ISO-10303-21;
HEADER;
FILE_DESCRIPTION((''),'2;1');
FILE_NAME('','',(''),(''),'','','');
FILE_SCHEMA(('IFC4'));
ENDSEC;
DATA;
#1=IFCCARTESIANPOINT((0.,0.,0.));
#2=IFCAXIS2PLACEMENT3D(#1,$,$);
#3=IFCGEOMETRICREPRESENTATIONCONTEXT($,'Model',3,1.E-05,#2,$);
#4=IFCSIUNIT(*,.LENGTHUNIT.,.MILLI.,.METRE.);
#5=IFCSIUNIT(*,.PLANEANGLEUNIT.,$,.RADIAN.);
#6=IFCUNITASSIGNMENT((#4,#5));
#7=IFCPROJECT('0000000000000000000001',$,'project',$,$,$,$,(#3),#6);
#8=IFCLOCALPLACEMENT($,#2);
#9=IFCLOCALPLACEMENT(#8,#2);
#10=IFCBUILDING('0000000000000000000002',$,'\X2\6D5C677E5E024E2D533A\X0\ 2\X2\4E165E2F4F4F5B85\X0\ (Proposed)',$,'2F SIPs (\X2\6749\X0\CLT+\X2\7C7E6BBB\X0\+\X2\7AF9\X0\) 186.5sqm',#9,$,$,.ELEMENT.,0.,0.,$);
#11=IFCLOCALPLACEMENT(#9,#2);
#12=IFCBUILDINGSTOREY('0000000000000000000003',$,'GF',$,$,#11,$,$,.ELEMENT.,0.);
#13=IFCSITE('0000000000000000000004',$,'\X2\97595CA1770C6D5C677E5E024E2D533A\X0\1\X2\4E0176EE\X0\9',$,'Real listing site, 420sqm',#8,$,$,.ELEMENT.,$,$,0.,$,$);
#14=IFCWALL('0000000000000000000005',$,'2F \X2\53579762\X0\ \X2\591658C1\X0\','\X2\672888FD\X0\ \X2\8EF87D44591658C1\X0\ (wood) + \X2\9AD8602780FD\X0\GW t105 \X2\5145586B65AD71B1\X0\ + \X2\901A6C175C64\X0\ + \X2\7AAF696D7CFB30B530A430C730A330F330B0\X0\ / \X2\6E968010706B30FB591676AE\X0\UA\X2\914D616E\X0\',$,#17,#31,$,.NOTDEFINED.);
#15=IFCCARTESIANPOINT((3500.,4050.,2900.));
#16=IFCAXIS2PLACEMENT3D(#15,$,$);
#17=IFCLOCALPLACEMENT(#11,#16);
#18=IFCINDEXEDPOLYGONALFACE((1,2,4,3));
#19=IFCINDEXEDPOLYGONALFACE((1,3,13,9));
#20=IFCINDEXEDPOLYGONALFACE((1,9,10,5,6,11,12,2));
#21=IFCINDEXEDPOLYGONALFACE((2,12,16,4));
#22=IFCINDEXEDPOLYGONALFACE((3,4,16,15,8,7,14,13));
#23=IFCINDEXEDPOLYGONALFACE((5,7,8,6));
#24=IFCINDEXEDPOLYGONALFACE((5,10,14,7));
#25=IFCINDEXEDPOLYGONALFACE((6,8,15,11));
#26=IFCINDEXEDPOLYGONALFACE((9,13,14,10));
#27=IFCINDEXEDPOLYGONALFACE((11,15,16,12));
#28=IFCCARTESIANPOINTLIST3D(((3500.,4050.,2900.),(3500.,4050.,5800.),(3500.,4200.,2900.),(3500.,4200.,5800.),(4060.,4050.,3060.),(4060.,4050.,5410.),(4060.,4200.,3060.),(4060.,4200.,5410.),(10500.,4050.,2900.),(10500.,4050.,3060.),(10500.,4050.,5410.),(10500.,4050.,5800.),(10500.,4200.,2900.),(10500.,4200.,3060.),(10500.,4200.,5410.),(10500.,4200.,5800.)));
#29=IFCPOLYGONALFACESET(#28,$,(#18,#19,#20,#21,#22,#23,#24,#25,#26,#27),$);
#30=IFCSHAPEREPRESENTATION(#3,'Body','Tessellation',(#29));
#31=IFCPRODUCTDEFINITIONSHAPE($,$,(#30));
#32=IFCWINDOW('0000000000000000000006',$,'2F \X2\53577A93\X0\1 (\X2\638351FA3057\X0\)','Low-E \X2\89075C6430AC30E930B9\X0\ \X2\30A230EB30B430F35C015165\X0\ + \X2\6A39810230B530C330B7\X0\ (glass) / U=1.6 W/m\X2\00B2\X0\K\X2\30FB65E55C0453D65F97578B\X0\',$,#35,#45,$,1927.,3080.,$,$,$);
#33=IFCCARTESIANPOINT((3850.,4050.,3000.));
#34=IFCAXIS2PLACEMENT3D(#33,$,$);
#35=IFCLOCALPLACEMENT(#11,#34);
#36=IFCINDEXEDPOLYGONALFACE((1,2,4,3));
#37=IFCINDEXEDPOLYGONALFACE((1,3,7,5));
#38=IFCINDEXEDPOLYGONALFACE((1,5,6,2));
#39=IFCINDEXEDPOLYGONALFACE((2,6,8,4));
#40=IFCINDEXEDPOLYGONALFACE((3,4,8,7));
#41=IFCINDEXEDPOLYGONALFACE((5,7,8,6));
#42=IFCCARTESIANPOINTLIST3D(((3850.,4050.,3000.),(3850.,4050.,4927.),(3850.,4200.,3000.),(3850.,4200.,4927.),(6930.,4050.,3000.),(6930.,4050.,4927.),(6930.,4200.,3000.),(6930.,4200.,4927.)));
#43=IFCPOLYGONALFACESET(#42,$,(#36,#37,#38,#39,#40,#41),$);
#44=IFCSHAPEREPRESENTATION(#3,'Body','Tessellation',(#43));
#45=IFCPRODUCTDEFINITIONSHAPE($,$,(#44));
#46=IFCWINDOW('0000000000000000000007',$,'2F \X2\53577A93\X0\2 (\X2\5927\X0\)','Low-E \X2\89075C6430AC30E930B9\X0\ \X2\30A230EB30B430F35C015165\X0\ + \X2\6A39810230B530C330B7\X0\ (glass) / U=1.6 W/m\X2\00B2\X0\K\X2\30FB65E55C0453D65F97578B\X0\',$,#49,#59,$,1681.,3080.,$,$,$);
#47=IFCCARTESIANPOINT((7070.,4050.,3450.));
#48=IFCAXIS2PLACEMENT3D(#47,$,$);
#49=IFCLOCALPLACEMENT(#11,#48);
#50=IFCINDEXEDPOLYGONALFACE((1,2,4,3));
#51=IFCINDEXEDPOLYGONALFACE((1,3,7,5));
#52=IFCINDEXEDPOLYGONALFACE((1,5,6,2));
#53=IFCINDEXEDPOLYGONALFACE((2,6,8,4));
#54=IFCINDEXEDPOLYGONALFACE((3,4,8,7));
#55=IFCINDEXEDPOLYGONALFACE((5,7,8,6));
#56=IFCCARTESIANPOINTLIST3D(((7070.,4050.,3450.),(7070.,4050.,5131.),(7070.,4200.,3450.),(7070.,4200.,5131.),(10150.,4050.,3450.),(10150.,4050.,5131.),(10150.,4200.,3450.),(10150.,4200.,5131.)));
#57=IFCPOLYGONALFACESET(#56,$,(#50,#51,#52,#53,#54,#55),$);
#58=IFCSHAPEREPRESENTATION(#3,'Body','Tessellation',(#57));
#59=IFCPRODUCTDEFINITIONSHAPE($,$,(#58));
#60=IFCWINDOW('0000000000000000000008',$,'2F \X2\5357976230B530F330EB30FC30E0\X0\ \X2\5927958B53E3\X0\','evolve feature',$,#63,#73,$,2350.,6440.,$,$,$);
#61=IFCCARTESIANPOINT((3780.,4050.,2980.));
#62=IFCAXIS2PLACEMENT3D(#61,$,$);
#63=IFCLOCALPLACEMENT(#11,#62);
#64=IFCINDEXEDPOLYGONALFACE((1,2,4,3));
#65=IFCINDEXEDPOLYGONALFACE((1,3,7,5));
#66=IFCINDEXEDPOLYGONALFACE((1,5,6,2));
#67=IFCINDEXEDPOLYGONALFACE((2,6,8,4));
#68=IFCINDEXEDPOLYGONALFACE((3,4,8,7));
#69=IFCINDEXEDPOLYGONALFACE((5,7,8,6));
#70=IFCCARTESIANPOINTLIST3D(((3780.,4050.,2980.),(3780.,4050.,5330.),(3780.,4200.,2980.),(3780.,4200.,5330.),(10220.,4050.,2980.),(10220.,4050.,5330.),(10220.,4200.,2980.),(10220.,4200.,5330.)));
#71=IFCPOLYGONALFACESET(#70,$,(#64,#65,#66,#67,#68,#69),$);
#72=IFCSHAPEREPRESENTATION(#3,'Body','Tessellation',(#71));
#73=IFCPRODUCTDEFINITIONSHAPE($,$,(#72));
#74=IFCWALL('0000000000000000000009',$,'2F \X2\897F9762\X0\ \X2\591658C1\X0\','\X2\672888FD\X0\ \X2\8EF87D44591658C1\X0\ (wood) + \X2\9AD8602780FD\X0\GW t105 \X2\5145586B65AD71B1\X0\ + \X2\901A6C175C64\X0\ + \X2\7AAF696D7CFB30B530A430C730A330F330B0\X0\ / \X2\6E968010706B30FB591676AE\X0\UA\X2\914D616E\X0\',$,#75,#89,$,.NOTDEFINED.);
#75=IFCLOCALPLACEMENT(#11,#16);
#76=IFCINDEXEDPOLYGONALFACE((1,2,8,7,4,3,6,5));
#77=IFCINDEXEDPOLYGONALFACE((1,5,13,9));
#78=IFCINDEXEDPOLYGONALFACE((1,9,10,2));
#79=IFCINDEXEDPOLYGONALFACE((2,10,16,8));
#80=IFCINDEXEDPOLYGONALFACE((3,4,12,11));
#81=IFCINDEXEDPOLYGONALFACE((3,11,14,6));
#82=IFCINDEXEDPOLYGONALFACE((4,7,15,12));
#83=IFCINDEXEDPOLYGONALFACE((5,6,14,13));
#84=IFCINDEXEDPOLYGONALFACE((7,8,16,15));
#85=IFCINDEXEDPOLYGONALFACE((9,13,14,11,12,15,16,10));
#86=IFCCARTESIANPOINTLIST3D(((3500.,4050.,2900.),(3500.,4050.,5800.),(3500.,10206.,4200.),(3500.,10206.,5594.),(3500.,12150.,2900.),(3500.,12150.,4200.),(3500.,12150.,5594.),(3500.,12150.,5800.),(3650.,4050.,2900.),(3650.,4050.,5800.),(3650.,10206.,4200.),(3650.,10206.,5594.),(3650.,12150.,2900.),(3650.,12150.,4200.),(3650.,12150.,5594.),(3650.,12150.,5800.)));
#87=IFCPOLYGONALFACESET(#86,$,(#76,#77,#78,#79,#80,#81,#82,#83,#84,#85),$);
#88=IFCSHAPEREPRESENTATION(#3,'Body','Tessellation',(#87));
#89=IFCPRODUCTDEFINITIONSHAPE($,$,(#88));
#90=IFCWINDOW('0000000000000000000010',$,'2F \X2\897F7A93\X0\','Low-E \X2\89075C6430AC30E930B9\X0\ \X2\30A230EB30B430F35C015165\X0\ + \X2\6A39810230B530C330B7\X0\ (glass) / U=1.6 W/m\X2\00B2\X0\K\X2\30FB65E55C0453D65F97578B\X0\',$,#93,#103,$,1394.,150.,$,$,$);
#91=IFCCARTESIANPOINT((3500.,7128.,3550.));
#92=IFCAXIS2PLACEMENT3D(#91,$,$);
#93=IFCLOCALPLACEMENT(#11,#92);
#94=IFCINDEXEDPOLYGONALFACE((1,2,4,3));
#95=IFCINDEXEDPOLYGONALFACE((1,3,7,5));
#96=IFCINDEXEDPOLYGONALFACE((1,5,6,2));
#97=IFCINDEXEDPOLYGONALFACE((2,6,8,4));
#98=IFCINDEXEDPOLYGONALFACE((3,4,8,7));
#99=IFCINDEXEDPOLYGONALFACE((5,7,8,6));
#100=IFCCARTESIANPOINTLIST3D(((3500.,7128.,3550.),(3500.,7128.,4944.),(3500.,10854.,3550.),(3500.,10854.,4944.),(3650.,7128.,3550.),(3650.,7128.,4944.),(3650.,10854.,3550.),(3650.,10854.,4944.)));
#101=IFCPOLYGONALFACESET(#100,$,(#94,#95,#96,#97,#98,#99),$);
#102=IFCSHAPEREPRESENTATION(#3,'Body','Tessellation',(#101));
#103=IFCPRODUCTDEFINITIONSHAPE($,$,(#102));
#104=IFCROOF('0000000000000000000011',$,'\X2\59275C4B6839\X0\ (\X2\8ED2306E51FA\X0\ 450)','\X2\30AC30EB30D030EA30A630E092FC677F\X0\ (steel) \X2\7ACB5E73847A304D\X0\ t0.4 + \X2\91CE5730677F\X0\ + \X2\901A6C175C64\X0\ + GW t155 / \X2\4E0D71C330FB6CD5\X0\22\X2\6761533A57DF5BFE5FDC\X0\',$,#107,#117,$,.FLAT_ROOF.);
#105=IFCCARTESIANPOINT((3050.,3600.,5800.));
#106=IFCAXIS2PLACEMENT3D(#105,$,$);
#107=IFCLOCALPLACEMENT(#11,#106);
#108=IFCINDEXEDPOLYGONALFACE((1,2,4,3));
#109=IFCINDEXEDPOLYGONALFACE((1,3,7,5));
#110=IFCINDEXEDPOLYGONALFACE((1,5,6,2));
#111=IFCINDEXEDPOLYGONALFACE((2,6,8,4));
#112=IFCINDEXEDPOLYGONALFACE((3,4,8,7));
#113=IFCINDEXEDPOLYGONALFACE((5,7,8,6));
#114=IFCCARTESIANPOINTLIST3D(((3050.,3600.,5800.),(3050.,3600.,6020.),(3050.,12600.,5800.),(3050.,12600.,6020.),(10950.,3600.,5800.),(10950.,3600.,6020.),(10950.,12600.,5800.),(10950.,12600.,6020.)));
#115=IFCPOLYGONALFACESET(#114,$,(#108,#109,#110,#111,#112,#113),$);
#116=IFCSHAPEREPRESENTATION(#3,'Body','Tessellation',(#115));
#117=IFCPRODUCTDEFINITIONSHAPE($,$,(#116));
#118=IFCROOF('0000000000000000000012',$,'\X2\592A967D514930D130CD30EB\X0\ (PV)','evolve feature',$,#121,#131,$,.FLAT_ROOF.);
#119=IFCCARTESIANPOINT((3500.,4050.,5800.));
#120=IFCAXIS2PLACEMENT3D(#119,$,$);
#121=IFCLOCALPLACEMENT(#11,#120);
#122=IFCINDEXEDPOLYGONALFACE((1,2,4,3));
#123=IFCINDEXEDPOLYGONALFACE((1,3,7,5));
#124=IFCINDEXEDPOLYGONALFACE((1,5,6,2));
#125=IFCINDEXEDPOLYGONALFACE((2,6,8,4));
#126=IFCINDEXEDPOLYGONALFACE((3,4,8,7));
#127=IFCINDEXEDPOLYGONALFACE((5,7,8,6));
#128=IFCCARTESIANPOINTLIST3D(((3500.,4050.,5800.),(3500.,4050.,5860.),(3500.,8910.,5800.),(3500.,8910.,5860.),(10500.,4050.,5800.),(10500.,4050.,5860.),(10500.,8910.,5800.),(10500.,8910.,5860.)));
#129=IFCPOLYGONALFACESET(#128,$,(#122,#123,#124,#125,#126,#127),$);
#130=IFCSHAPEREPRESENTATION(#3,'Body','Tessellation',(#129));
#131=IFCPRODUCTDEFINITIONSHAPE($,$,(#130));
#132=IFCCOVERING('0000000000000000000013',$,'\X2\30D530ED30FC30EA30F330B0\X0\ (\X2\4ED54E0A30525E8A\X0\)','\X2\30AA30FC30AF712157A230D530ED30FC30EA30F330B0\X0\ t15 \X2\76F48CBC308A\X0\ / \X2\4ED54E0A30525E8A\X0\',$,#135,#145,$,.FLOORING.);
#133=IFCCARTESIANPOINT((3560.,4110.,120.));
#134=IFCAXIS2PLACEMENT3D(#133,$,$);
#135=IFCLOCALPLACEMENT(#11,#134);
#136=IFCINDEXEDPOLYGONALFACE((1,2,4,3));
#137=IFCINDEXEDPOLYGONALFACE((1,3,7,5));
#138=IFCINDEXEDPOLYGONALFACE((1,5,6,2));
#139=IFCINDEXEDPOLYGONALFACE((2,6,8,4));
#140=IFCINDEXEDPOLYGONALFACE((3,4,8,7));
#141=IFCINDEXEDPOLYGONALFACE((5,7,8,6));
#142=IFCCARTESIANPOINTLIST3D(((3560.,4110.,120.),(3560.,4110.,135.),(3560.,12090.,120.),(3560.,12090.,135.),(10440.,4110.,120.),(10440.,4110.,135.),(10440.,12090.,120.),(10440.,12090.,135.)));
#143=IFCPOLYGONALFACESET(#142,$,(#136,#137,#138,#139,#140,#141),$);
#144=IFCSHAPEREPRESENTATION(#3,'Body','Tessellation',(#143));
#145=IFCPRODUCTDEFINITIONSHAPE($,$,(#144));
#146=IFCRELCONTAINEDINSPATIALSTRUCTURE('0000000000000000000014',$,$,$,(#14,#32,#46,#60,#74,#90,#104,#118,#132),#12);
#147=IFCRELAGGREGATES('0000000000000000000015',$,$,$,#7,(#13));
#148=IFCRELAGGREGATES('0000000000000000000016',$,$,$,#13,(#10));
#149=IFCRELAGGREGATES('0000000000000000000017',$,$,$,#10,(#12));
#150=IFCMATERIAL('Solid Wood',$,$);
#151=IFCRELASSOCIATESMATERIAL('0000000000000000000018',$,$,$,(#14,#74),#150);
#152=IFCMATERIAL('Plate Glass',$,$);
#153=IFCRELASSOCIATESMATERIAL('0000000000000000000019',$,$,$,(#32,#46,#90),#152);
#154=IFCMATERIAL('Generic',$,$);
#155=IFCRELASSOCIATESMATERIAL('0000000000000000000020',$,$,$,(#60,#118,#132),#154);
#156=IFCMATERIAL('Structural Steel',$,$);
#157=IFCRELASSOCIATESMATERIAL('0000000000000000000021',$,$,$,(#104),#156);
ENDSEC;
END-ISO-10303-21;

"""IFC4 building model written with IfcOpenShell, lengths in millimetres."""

from ifc_helpers import new_model, si_unit, frame, frame_2d, origin, place, context, project, spatial, rectangle, extrude, material, element, fill, save


model = new_model("IFC4")

# Units and contexts
model_context = context("Model", 3, precision=1e-05, world=origin())
ifc_project = project(units=[si_unit("LENGTHUNIT", "METRE", prefix="MILLI"), si_unit("PLANEANGLEUNIT", "RADIAN")], contexts=[model_context])

# Site, building, storey
site_placement = place(None, origin())
site = spatial("IfcSite", under=ifc_project, at=site_placement, Name="静岡県浜松市中区1丁目9", ObjectType="Real listing site, 420sqm", CompositionType="ELEMENT", RefElevation=0.0)
building_placement = place(site_placement, origin())
building = spatial("IfcBuilding", under=site, at=building_placement, Name="浜松市中区 2世帯住宅 (Proposed)", ObjectType="2F SIPs (杉CLT+籾殻+竹) 186.5sqm", CompositionType="ELEMENT", ElevationOfRefHeight=0.0, ElevationOfTerrain=0.0)
storey_placement = place(building_placement, origin())
storey = spatial("IfcBuildingStorey", under=building, at=storey_placement, Name="GF", CompositionType="ELEMENT", Elevation=0.0)

# Shared definitions
ifc_material_1 = material(Name="Solid Wood")
ifc_material_2 = material(Name="Generic")

# Shared definitions
ifc_material_3 = material(Name="Plate Glass")

# Wall, openings, windows
wall_1_placement = place(storey_placement, frame((3500.0, 4050.0, 2900.0)))
wall_1 = element("IfcWall", 1, at=wall_1_placement, inside=storey, material=ifc_material_1, Name="2F 南面 外壁", Description="木製 軸組外壁 (wood) + 高性能GW t105 充填断熱 + 通気層 + 窯業系サイディング / 準耐火・外皮UA配慮", PredefinedType="NOTDEFINED", context=model_context, shape_type="SweptSolid", body=[
    extrude(rectangle(XDim=7000.0, YDim=150.0, at=frame_2d((3500.0, 75.0))), frame((3500.0, 4050.0, 2900.0)), (0.0, 0.0, 1.0), 2900.0),
])
opening_1_placement = place(storey_placement, frame((3850.0, 4050.0, 3000.0)))
opening_1 = element("IfcOpeningElement", 2, at=opening_1_placement, cuts=wall_1, PredefinedType="NOTDEFINED", context=model_context, shape_type="SweptSolid", body=[
    extrude(rectangle(XDim=3080.0, YDim=150.0, at=frame_2d((1540.0, 75.0))), frame((3850.0, 4050.0, 3000.0)), (0.0, 0.0, 1.0), 1927.0),
])
opening_2_placement = place(storey_placement, frame((7070.0, 4050.0, 3450.0)))
opening_2 = element("IfcOpeningElement", 3, at=opening_2_placement, cuts=wall_1, PredefinedType="NOTDEFINED", context=model_context, shape_type="SweptSolid", body=[
    extrude(rectangle(XDim=3080.0, YDim=150.0, at=frame_2d((1540.0, 75.0))), frame((7070.0, 4050.0, 3450.0)), (0.0, 0.0, 1.0), 1681.0),
])
opening_3_placement = place(storey_placement, frame((3780.0, 4050.0, 2980.0)))
opening_3 = element("IfcOpeningElement", 4, at=opening_3_placement, cuts=wall_1, PredefinedType="NOTDEFINED", context=model_context, shape_type="SweptSolid", body=[
    extrude(rectangle(XDim=6440.0, YDim=150.0, at=frame_2d((3220.0, 75.0))), frame((3780.0, 4050.0, 2980.0)), (0.0, 0.0, 1.0), 2350.0),
])
window_1_placement = place(storey_placement, frame((3850.0, 4050.0, 3000.0)))
window_1 = element("IfcWindow", 5, at=window_1_placement, inside=storey, material=ifc_material_3, Name="2F 南窓1 (掃出し)", Description="Low-E 複層ガラス アルゴン封入 + 樹脂サッシ (glass) / U=1.6 W/m²K・日射取得型", OverallHeight=1927.0, OverallWidth=3080.0, context=model_context, shape_type="SweptSolid", body=[
    extrude(rectangle(XDim=3080.0, YDim=150.0, at=frame_2d((1540.0, 75.0))), frame((3850.0, 4050.0, 3000.0)), (0.0, 0.0, 1.0), 1927.0),
])
fill(opening_1, window_1)
window_2_placement = place(storey_placement, frame((7070.0, 4050.0, 3450.0)))
window_2 = element("IfcWindow", 6, at=window_2_placement, inside=storey, material=ifc_material_3, Name="2F 南窓2 (大)", Description="Low-E 複層ガラス アルゴン封入 + 樹脂サッシ (glass) / U=1.6 W/m²K・日射取得型", OverallHeight=1681.0, OverallWidth=3080.0, context=model_context, shape_type="SweptSolid", body=[
    extrude(rectangle(XDim=3080.0, YDim=150.0, at=frame_2d((1540.0, 75.0))), frame((7070.0, 4050.0, 3450.0)), (0.0, 0.0, 1.0), 1681.0),
])
fill(opening_2, window_2)
window_3_placement = place(storey_placement, frame((3780.0, 4050.0, 2980.0)))
window_3 = element("IfcWindow", 7, at=window_3_placement, inside=storey, material=ifc_material_2, Name="2F 南面サンルーム 大開口", Description="evolve feature", OverallHeight=2350.0, OverallWidth=6440.0, context=model_context, shape_type="SweptSolid", body=[
    extrude(rectangle(XDim=6440.0, YDim=150.0, at=frame_2d((3220.0, 75.0))), frame((3780.0, 4050.0, 2980.0)), (0.0, 0.0, 1.0), 2350.0),
])
fill(opening_3, window_3)

# Wall, opening, window
wall_2_placement = place(storey_placement, frame((3500.0, 4050.0, 2900.0)))
wall_2 = element("IfcWall", 8, at=wall_2_placement, inside=storey, material=ifc_material_1, Name="2F 西面 外壁", Description="木製 軸組外壁 (wood) + 高性能GW t105 充填断熱 + 通気層 + 窯業系サイディング / 準耐火・外皮UA配慮", PredefinedType="NOTDEFINED", context=model_context, shape_type="SweptSolid", body=[
    extrude(rectangle(XDim=150.0, YDim=8100.0, at=frame_2d((75.0, 4050.0))), frame((3500.0, 4050.0, 2900.0)), (0.0, 0.0, 1.0), 2900.0),
])
opening_4_placement = place(storey_placement, frame((3500.0, 7128.0, 3550.0)))
opening_4 = element("IfcOpeningElement", 9, at=opening_4_placement, cuts=wall_2, PredefinedType="NOTDEFINED", context=model_context, shape_type="SweptSolid", body=[
    extrude(rectangle(XDim=150.0, YDim=3726.0, at=frame_2d((75.0, 1863.0))), frame((3500.0, 7128.0, 3550.0)), (0.0, 0.0, 1.0), 1394.0),
])
window_4_placement = place(storey_placement, frame((3500.0, 7128.0, 3550.0)))
window_4 = element("IfcWindow", 10, at=window_4_placement, inside=storey, material=ifc_material_3, Name="2F 西窓", Description="Low-E 複層ガラス アルゴン封入 + 樹脂サッシ (glass) / U=1.6 W/m²K・日射取得型", OverallHeight=1394.0, OverallWidth=150.0, context=model_context, shape_type="SweptSolid", body=[
    extrude(rectangle(XDim=150.0, YDim=3726.0, at=frame_2d((75.0, 1863.0))), frame((3500.0, 7128.0, 3550.0)), (0.0, 0.0, 1.0), 1394.0),
])
fill(opening_4, window_4)

# Roofs
ifc_material_4 = material(Name="Structural Steel")
roof_1_placement = place(storey_placement, frame((3050.0, 3600.0, 5800.0)))
element("IfcRoof", 11, at=roof_1_placement, inside=storey, material=ifc_material_4, Name="大屋根 (軒の出 450)", Description="ガルバリウム鋼板 (steel) 立平葺き t0.4 + 野地板 + 通気層 + GW t155 / 不燃・法22条区域対応", PredefinedType="FLAT_ROOF", context=model_context, shape_type="SweptSolid", body=[
    extrude(rectangle(XDim=7900.0, YDim=9000.0, at=frame_2d((3950.0, 4500.0))), frame((3050.0, 3600.0, 5800.0)), (0.0, 0.0, 1.0), 220.0),
])
roof_2_placement = place(storey_placement, frame((3500.0, 4050.0, 5800.0)))
element("IfcRoof", 12, at=roof_2_placement, inside=storey, material=ifc_material_2, Name="太陽光パネル (PV)", Description="evolve feature", PredefinedType="FLAT_ROOF", context=model_context, shape_type="SweptSolid", body=[
    extrude(rectangle(XDim=7000.0, YDim=4860.0, at=frame_2d((3500.0, 2430.0))), frame((3500.0, 4050.0, 5800.0)), (0.0, 0.0, 1.0), 60.0),
])

# Covering
covering_placement = place(storey_placement, frame((3560.0, 4110.0, 120.0)))
element("IfcCovering", 13, at=covering_placement, inside=storey, material=ifc_material_2, Name="フローリング (仕上げ床)", Description="オーク無垢フローリング t15 直貼り / 仕上げ床", PredefinedType="FLOORING", context=model_context, shape_type="SweptSolid", body=[
    extrude(rectangle(XDim=6880.0, YDim=7980.0, at=frame_2d((3440.0, 3990.0))), frame((3560.0, 4110.0, 120.0)), (0.0, 0.0, 1.0), 15.0),
])

save(model, "model.ifc")
